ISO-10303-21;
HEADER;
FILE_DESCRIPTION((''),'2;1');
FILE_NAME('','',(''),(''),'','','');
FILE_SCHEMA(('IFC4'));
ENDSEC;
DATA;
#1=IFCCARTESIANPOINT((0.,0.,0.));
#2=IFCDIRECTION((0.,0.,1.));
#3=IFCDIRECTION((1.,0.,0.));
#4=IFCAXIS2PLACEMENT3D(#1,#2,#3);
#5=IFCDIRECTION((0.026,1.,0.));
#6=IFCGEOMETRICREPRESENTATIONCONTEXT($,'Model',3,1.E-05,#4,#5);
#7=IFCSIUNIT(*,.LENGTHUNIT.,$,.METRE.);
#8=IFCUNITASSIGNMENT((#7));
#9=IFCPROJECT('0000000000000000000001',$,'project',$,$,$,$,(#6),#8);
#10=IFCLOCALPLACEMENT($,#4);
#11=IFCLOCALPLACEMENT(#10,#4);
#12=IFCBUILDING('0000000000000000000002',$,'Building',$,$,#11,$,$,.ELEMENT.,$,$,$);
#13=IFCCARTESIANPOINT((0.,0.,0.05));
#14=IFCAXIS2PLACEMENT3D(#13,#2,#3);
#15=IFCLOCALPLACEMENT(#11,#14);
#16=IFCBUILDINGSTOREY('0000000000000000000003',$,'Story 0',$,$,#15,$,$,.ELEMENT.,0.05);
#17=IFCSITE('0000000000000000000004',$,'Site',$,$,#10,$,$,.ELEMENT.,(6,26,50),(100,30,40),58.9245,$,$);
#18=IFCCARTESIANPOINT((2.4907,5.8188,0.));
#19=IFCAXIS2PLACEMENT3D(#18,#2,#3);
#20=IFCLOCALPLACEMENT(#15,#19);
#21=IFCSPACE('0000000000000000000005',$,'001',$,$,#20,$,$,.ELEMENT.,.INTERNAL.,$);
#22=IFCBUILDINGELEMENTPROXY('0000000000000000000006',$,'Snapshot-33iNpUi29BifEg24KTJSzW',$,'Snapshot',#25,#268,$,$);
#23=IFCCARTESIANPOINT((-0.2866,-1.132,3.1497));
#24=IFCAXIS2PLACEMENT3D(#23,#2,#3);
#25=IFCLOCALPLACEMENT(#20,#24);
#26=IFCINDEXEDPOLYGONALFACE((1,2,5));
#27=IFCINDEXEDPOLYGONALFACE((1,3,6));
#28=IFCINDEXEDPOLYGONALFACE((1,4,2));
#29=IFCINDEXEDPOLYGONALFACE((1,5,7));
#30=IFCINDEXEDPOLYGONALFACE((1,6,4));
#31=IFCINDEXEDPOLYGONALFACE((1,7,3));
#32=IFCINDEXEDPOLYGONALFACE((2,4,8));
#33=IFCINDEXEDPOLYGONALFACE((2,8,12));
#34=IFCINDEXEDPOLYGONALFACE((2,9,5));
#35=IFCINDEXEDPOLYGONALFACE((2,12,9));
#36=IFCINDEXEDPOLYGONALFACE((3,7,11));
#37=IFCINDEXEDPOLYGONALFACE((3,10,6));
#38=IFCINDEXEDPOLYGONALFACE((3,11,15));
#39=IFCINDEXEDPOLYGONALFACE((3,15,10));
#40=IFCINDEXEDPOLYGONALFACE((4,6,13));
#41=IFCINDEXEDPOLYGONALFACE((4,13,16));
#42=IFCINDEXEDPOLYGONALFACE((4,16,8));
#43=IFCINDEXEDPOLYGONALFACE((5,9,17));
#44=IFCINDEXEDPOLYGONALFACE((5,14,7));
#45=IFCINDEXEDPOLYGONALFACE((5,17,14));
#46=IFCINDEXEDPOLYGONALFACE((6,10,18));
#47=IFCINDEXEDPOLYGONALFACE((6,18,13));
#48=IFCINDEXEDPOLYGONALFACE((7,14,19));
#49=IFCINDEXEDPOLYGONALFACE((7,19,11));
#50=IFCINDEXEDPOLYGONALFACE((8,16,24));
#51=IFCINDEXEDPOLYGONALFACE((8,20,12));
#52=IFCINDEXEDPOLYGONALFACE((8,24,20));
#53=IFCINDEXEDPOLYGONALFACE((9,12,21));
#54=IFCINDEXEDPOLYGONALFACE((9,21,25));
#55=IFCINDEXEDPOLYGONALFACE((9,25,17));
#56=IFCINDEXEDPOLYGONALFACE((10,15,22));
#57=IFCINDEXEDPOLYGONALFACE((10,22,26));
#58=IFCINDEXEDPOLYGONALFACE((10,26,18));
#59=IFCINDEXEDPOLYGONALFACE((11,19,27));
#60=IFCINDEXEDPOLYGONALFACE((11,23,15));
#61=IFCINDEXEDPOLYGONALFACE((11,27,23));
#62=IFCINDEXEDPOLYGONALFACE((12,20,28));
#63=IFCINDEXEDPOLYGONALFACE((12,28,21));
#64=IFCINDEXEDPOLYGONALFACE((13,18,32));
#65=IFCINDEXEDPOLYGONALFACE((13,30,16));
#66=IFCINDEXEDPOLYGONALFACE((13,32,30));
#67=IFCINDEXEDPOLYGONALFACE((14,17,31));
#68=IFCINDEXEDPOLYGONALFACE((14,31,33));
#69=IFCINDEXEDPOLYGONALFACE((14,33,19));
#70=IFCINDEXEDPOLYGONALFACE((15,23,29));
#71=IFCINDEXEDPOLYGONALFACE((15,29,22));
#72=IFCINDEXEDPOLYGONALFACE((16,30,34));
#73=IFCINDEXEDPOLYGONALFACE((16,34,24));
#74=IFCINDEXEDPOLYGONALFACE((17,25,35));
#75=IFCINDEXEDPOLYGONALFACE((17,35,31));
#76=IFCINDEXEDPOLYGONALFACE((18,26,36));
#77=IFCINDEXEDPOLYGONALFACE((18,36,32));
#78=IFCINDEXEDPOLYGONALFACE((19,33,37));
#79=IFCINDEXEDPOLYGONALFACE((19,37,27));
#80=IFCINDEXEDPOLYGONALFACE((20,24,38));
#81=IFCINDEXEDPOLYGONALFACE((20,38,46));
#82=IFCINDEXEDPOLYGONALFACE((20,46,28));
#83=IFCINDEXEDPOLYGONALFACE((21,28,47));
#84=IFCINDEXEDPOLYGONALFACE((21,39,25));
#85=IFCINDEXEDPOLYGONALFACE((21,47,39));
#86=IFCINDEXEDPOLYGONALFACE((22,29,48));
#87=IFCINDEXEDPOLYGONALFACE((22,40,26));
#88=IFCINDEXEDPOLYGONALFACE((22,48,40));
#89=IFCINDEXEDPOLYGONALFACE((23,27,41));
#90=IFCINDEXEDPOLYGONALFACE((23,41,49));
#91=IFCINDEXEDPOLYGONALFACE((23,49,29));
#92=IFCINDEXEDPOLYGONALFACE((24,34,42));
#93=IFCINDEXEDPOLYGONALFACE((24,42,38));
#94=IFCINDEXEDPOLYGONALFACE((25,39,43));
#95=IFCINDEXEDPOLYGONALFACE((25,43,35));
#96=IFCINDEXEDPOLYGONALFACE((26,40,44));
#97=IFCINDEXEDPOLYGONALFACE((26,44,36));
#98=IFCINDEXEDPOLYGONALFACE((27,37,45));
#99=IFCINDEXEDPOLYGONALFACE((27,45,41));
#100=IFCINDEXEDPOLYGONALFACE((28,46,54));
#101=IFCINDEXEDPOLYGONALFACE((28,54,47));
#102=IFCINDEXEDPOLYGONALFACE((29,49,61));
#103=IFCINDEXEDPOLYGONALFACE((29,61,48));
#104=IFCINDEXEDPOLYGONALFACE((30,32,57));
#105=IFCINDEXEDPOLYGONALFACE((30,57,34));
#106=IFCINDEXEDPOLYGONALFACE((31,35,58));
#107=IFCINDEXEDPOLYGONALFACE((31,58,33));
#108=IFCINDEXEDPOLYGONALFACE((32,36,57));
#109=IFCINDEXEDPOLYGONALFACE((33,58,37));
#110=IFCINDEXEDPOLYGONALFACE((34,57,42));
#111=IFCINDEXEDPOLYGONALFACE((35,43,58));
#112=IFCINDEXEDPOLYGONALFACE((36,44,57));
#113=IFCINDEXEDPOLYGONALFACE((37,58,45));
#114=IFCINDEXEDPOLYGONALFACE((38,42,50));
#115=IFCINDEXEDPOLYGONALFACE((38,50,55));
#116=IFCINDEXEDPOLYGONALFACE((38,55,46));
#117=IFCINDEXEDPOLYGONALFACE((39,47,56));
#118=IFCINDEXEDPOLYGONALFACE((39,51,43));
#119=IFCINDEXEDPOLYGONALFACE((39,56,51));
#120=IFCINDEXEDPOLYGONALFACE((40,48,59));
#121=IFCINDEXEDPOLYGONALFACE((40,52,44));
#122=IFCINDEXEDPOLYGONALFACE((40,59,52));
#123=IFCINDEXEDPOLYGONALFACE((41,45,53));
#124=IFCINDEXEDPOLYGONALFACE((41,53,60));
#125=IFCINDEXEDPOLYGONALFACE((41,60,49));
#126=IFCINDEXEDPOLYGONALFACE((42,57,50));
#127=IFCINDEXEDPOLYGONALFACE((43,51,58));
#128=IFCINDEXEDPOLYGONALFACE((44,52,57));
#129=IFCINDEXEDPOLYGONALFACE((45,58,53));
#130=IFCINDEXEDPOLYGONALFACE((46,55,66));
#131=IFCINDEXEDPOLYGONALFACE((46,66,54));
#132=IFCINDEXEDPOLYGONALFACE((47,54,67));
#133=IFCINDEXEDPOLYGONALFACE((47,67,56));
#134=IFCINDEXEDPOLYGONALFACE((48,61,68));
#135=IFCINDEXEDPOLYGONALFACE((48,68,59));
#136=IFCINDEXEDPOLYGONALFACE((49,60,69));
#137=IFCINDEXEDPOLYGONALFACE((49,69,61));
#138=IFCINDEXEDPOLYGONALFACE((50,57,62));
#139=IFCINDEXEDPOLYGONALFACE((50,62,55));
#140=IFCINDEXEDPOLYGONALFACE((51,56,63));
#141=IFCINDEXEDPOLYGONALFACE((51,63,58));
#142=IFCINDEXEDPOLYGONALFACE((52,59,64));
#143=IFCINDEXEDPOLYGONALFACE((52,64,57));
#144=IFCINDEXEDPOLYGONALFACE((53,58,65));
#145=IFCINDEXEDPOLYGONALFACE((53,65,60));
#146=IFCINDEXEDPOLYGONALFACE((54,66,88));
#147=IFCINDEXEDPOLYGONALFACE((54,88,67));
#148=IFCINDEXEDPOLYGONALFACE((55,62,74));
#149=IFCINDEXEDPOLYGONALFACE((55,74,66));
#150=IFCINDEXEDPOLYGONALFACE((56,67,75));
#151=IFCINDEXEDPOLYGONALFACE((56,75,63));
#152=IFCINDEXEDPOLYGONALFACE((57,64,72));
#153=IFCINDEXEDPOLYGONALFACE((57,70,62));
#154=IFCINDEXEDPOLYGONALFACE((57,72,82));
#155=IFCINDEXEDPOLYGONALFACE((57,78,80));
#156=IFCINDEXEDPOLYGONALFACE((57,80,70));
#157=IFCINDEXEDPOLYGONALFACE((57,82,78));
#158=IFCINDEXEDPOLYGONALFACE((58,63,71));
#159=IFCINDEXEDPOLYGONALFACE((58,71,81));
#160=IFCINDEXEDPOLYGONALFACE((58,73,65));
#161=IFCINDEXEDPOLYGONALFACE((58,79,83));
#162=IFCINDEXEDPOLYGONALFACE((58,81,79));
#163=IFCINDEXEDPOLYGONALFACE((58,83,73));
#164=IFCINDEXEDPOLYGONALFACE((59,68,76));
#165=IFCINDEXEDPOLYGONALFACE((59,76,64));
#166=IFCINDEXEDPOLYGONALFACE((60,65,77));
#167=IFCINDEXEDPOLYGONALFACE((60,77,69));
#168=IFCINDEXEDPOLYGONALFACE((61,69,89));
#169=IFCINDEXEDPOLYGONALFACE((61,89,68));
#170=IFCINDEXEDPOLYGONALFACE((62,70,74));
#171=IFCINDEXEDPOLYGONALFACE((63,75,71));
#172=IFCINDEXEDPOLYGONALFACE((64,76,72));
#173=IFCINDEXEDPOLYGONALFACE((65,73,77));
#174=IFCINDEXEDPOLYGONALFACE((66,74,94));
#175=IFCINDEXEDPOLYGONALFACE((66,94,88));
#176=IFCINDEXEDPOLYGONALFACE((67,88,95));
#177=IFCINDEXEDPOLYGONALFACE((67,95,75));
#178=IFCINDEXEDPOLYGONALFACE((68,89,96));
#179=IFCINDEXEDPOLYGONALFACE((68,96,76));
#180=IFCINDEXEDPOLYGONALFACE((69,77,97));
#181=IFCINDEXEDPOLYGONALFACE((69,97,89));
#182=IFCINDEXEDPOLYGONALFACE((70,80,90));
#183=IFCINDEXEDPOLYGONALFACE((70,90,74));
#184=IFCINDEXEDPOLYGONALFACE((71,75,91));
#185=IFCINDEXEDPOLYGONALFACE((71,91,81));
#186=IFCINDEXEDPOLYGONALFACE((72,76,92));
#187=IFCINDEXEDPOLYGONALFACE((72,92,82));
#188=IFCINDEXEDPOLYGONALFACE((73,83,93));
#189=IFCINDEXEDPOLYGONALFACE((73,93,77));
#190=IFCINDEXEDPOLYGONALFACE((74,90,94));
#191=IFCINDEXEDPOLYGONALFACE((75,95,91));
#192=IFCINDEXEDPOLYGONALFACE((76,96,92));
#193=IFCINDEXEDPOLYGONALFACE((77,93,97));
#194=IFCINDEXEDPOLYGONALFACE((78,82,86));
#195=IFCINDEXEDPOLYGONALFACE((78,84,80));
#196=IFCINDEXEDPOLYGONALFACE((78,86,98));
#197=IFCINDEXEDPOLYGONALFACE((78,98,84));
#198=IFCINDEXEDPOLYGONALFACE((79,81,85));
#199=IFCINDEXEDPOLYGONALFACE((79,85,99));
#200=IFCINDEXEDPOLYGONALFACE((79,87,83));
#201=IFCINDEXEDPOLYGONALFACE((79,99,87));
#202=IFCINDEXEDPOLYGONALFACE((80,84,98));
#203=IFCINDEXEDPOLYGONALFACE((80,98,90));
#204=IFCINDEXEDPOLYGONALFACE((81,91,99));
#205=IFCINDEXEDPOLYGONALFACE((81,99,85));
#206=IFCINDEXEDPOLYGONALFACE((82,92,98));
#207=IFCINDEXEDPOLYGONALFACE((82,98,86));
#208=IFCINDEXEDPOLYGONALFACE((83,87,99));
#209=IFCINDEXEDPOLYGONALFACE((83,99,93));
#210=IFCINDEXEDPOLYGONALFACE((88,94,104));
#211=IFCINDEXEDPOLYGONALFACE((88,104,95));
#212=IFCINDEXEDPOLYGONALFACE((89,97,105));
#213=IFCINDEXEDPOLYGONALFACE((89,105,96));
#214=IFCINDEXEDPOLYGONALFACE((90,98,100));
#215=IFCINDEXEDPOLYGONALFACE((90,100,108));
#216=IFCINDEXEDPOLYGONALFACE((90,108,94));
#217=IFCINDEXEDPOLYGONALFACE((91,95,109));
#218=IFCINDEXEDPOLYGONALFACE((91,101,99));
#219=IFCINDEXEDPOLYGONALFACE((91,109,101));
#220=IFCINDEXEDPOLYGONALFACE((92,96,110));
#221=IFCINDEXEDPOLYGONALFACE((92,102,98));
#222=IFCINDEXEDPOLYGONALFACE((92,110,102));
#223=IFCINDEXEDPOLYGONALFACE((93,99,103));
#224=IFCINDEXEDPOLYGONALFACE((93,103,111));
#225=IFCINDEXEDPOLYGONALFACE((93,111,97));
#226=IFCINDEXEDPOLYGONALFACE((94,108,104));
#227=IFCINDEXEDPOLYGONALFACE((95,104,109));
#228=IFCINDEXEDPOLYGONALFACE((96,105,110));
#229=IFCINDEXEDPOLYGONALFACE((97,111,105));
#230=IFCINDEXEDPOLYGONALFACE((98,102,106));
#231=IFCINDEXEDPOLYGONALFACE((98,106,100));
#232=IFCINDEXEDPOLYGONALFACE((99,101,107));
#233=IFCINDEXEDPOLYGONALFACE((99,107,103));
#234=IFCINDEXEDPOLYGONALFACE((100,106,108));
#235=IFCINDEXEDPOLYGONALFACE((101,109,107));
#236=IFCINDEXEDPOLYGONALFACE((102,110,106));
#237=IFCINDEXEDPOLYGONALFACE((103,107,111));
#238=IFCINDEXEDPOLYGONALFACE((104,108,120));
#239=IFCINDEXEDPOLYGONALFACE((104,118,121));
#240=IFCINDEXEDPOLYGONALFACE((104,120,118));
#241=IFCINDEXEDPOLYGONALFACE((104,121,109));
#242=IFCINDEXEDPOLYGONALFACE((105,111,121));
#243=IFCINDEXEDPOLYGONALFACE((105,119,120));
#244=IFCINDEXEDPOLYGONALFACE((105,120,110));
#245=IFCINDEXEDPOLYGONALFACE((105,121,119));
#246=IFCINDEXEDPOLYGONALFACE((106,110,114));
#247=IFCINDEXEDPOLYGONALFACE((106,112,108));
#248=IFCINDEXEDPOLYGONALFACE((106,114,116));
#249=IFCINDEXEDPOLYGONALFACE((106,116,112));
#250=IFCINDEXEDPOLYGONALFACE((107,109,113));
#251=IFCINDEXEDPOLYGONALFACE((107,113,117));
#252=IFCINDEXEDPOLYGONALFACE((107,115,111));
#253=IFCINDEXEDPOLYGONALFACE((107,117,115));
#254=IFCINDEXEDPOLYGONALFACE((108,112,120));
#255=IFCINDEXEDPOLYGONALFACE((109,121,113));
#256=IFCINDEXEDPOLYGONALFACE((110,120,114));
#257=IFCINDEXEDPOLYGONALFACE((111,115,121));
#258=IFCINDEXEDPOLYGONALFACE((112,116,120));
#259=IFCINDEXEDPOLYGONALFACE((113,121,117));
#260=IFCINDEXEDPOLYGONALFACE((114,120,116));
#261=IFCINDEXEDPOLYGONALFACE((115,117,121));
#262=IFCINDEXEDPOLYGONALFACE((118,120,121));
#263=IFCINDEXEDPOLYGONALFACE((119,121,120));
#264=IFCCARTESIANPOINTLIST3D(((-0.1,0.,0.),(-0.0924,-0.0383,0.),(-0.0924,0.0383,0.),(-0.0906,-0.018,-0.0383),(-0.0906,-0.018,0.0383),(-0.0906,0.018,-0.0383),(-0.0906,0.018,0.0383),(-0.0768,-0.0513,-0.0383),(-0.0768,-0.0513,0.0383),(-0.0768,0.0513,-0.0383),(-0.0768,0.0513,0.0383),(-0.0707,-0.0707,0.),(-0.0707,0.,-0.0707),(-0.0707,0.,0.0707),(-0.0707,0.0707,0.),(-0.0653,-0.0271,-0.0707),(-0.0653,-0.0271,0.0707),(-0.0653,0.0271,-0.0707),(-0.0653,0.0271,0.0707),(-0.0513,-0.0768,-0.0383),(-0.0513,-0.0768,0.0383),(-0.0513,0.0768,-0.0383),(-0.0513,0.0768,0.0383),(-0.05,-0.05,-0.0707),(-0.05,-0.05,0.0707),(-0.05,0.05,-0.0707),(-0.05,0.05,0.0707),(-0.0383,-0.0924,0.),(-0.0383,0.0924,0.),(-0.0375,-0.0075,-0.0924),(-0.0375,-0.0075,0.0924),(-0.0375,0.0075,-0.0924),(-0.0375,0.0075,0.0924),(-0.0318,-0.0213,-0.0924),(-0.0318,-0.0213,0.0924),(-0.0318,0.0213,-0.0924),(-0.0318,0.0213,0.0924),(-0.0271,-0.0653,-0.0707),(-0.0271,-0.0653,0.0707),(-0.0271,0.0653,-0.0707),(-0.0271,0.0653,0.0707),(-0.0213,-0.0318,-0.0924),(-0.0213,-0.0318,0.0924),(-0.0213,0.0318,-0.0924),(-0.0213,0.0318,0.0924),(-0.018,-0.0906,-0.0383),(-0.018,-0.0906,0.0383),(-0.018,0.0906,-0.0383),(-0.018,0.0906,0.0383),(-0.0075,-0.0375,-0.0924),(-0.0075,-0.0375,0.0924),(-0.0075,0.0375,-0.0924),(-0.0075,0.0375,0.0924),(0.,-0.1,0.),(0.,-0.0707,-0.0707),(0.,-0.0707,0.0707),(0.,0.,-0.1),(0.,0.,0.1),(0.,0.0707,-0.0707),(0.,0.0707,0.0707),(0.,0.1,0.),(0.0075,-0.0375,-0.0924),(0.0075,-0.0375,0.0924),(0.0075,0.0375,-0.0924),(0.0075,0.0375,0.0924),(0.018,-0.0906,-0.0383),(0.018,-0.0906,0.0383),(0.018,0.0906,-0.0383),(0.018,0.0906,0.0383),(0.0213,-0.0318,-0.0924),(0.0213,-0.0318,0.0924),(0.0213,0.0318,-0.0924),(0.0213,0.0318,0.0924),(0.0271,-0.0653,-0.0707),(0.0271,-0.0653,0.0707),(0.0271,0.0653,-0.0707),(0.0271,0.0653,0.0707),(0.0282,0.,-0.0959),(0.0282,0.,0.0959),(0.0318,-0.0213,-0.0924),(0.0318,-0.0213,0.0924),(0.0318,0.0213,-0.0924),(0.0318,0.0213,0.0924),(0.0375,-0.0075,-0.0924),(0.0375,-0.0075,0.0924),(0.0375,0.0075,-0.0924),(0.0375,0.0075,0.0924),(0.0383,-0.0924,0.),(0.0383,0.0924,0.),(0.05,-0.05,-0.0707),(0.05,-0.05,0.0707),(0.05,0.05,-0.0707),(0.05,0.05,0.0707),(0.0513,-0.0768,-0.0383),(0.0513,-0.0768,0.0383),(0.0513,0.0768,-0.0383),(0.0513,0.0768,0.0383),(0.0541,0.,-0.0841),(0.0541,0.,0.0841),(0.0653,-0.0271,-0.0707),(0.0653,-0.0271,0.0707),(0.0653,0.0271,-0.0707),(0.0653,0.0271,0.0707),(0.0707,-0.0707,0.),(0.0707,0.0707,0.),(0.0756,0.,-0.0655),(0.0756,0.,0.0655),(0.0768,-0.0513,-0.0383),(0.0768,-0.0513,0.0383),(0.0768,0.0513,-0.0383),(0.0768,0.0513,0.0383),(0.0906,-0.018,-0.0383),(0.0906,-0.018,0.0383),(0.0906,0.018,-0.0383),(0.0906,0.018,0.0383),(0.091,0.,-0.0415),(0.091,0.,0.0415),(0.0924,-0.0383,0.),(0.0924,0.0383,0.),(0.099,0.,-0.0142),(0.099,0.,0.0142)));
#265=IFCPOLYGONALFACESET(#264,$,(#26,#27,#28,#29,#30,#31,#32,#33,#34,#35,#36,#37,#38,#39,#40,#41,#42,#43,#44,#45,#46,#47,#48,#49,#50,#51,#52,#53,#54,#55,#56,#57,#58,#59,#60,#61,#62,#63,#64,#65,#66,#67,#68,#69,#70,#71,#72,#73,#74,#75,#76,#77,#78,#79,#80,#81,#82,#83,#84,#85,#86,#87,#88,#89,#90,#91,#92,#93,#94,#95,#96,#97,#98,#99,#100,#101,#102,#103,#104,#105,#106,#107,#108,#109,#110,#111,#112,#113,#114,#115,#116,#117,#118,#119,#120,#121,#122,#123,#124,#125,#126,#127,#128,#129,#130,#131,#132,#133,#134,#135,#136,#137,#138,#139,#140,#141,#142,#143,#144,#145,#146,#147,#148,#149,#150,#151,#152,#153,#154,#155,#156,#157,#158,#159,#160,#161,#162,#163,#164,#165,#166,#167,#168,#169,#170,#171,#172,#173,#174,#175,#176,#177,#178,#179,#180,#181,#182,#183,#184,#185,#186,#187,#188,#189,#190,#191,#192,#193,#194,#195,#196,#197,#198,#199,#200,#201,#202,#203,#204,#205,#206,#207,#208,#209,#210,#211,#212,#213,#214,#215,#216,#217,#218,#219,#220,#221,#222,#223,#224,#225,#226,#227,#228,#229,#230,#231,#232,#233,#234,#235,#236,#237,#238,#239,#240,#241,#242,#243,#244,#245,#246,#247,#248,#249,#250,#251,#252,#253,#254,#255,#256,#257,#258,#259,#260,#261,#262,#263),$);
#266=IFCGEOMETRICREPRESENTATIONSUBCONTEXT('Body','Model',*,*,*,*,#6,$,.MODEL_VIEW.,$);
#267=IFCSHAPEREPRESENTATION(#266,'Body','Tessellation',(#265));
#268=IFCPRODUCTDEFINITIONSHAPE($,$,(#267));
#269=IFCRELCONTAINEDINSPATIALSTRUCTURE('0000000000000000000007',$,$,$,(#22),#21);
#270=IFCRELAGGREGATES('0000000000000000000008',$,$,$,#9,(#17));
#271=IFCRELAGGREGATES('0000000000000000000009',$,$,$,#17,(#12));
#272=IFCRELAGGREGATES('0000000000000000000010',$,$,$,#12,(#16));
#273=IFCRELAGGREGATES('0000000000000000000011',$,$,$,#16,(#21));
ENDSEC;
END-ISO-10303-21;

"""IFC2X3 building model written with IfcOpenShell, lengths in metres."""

from ifc_helpers import new_model, entity, si_unit, direction, frame, origin_with_axes, place, context, subcontext, project, spatial, element, save


model = new_model("IFC2X3")

# Units and contexts
model_context = context("Model", 3, precision=1e-05, world=origin_with_axes(), true_north=direction((0.026, 1.0, 0.0)))
body_context = subcontext(model_context, "Body", "Model", "MODEL_VIEW")
ifc_project = project(units=[si_unit("LENGTHUNIT", "METRE")], contexts=[model_context])

# Site, building, storey
site_placement = place(None, origin_with_axes())
site = spatial("IfcSite", under=ifc_project, at=site_placement, Name="Site", CompositionType="ELEMENT", RefLatitude=(6, 26, 50), RefLongitude=(100, 30, 40), RefElevation=58.9245)
building_placement = place(site_placement, origin_with_axes())
building = spatial("IfcBuilding", under=site, at=building_placement, Name="Building", CompositionType="ELEMENT")
storey_placement = place(building_placement, frame((0.0, 0.0, 0.05), z_axis=(0.0, 0.0, 1.0), x_axis=(1.0, 0.0, 0.0)))
storey = spatial("IfcBuildingStorey", under=building, at=storey_placement, Name="Story 0", CompositionType="ELEMENT", Elevation=0.05)

# Shared definitions
space_placement = place(storey_placement, frame((2.4907, 5.8188, 0.0), z_axis=(0.0, 0.0, 1.0), x_axis=(1.0, 0.0, 0.0)))
space = spatial("IfcSpace", under=storey, at=space_placement, Name="001", CompositionType="ELEMENT", InteriorOrExteriorSpace="INTERNAL")

# Building element proxy
for number, where, z_axis, x_axis, name in (
    (1, (-0.2866, -1.132, 3.1497), (0.0, 0.0, 1.0), (1.0, 0.0, 0.0), "Snapshot-33iNpUi29BifEg24KTJSzW"),
):
    element("IfcBuildingElementProxy", number, at=place(space_placement, frame(where, z_axis=z_axis, x_axis=x_axis)), inside=space, Name=name, ObjectType="Snapshot", context=body_context, shape_type="CSG", body=[
        entity("IfcSphere", entity("IfcAxis2Placement3D", entity("IfcCartesianPoint", [0.0, 0.0, 0.0]), entity("IfcDirection", [0.0, 0.0, 1.0]), entity("IfcDirection", [1.0, 0.0, 0.0])), 0.1),
    ])

save(model, "model.ifc")
